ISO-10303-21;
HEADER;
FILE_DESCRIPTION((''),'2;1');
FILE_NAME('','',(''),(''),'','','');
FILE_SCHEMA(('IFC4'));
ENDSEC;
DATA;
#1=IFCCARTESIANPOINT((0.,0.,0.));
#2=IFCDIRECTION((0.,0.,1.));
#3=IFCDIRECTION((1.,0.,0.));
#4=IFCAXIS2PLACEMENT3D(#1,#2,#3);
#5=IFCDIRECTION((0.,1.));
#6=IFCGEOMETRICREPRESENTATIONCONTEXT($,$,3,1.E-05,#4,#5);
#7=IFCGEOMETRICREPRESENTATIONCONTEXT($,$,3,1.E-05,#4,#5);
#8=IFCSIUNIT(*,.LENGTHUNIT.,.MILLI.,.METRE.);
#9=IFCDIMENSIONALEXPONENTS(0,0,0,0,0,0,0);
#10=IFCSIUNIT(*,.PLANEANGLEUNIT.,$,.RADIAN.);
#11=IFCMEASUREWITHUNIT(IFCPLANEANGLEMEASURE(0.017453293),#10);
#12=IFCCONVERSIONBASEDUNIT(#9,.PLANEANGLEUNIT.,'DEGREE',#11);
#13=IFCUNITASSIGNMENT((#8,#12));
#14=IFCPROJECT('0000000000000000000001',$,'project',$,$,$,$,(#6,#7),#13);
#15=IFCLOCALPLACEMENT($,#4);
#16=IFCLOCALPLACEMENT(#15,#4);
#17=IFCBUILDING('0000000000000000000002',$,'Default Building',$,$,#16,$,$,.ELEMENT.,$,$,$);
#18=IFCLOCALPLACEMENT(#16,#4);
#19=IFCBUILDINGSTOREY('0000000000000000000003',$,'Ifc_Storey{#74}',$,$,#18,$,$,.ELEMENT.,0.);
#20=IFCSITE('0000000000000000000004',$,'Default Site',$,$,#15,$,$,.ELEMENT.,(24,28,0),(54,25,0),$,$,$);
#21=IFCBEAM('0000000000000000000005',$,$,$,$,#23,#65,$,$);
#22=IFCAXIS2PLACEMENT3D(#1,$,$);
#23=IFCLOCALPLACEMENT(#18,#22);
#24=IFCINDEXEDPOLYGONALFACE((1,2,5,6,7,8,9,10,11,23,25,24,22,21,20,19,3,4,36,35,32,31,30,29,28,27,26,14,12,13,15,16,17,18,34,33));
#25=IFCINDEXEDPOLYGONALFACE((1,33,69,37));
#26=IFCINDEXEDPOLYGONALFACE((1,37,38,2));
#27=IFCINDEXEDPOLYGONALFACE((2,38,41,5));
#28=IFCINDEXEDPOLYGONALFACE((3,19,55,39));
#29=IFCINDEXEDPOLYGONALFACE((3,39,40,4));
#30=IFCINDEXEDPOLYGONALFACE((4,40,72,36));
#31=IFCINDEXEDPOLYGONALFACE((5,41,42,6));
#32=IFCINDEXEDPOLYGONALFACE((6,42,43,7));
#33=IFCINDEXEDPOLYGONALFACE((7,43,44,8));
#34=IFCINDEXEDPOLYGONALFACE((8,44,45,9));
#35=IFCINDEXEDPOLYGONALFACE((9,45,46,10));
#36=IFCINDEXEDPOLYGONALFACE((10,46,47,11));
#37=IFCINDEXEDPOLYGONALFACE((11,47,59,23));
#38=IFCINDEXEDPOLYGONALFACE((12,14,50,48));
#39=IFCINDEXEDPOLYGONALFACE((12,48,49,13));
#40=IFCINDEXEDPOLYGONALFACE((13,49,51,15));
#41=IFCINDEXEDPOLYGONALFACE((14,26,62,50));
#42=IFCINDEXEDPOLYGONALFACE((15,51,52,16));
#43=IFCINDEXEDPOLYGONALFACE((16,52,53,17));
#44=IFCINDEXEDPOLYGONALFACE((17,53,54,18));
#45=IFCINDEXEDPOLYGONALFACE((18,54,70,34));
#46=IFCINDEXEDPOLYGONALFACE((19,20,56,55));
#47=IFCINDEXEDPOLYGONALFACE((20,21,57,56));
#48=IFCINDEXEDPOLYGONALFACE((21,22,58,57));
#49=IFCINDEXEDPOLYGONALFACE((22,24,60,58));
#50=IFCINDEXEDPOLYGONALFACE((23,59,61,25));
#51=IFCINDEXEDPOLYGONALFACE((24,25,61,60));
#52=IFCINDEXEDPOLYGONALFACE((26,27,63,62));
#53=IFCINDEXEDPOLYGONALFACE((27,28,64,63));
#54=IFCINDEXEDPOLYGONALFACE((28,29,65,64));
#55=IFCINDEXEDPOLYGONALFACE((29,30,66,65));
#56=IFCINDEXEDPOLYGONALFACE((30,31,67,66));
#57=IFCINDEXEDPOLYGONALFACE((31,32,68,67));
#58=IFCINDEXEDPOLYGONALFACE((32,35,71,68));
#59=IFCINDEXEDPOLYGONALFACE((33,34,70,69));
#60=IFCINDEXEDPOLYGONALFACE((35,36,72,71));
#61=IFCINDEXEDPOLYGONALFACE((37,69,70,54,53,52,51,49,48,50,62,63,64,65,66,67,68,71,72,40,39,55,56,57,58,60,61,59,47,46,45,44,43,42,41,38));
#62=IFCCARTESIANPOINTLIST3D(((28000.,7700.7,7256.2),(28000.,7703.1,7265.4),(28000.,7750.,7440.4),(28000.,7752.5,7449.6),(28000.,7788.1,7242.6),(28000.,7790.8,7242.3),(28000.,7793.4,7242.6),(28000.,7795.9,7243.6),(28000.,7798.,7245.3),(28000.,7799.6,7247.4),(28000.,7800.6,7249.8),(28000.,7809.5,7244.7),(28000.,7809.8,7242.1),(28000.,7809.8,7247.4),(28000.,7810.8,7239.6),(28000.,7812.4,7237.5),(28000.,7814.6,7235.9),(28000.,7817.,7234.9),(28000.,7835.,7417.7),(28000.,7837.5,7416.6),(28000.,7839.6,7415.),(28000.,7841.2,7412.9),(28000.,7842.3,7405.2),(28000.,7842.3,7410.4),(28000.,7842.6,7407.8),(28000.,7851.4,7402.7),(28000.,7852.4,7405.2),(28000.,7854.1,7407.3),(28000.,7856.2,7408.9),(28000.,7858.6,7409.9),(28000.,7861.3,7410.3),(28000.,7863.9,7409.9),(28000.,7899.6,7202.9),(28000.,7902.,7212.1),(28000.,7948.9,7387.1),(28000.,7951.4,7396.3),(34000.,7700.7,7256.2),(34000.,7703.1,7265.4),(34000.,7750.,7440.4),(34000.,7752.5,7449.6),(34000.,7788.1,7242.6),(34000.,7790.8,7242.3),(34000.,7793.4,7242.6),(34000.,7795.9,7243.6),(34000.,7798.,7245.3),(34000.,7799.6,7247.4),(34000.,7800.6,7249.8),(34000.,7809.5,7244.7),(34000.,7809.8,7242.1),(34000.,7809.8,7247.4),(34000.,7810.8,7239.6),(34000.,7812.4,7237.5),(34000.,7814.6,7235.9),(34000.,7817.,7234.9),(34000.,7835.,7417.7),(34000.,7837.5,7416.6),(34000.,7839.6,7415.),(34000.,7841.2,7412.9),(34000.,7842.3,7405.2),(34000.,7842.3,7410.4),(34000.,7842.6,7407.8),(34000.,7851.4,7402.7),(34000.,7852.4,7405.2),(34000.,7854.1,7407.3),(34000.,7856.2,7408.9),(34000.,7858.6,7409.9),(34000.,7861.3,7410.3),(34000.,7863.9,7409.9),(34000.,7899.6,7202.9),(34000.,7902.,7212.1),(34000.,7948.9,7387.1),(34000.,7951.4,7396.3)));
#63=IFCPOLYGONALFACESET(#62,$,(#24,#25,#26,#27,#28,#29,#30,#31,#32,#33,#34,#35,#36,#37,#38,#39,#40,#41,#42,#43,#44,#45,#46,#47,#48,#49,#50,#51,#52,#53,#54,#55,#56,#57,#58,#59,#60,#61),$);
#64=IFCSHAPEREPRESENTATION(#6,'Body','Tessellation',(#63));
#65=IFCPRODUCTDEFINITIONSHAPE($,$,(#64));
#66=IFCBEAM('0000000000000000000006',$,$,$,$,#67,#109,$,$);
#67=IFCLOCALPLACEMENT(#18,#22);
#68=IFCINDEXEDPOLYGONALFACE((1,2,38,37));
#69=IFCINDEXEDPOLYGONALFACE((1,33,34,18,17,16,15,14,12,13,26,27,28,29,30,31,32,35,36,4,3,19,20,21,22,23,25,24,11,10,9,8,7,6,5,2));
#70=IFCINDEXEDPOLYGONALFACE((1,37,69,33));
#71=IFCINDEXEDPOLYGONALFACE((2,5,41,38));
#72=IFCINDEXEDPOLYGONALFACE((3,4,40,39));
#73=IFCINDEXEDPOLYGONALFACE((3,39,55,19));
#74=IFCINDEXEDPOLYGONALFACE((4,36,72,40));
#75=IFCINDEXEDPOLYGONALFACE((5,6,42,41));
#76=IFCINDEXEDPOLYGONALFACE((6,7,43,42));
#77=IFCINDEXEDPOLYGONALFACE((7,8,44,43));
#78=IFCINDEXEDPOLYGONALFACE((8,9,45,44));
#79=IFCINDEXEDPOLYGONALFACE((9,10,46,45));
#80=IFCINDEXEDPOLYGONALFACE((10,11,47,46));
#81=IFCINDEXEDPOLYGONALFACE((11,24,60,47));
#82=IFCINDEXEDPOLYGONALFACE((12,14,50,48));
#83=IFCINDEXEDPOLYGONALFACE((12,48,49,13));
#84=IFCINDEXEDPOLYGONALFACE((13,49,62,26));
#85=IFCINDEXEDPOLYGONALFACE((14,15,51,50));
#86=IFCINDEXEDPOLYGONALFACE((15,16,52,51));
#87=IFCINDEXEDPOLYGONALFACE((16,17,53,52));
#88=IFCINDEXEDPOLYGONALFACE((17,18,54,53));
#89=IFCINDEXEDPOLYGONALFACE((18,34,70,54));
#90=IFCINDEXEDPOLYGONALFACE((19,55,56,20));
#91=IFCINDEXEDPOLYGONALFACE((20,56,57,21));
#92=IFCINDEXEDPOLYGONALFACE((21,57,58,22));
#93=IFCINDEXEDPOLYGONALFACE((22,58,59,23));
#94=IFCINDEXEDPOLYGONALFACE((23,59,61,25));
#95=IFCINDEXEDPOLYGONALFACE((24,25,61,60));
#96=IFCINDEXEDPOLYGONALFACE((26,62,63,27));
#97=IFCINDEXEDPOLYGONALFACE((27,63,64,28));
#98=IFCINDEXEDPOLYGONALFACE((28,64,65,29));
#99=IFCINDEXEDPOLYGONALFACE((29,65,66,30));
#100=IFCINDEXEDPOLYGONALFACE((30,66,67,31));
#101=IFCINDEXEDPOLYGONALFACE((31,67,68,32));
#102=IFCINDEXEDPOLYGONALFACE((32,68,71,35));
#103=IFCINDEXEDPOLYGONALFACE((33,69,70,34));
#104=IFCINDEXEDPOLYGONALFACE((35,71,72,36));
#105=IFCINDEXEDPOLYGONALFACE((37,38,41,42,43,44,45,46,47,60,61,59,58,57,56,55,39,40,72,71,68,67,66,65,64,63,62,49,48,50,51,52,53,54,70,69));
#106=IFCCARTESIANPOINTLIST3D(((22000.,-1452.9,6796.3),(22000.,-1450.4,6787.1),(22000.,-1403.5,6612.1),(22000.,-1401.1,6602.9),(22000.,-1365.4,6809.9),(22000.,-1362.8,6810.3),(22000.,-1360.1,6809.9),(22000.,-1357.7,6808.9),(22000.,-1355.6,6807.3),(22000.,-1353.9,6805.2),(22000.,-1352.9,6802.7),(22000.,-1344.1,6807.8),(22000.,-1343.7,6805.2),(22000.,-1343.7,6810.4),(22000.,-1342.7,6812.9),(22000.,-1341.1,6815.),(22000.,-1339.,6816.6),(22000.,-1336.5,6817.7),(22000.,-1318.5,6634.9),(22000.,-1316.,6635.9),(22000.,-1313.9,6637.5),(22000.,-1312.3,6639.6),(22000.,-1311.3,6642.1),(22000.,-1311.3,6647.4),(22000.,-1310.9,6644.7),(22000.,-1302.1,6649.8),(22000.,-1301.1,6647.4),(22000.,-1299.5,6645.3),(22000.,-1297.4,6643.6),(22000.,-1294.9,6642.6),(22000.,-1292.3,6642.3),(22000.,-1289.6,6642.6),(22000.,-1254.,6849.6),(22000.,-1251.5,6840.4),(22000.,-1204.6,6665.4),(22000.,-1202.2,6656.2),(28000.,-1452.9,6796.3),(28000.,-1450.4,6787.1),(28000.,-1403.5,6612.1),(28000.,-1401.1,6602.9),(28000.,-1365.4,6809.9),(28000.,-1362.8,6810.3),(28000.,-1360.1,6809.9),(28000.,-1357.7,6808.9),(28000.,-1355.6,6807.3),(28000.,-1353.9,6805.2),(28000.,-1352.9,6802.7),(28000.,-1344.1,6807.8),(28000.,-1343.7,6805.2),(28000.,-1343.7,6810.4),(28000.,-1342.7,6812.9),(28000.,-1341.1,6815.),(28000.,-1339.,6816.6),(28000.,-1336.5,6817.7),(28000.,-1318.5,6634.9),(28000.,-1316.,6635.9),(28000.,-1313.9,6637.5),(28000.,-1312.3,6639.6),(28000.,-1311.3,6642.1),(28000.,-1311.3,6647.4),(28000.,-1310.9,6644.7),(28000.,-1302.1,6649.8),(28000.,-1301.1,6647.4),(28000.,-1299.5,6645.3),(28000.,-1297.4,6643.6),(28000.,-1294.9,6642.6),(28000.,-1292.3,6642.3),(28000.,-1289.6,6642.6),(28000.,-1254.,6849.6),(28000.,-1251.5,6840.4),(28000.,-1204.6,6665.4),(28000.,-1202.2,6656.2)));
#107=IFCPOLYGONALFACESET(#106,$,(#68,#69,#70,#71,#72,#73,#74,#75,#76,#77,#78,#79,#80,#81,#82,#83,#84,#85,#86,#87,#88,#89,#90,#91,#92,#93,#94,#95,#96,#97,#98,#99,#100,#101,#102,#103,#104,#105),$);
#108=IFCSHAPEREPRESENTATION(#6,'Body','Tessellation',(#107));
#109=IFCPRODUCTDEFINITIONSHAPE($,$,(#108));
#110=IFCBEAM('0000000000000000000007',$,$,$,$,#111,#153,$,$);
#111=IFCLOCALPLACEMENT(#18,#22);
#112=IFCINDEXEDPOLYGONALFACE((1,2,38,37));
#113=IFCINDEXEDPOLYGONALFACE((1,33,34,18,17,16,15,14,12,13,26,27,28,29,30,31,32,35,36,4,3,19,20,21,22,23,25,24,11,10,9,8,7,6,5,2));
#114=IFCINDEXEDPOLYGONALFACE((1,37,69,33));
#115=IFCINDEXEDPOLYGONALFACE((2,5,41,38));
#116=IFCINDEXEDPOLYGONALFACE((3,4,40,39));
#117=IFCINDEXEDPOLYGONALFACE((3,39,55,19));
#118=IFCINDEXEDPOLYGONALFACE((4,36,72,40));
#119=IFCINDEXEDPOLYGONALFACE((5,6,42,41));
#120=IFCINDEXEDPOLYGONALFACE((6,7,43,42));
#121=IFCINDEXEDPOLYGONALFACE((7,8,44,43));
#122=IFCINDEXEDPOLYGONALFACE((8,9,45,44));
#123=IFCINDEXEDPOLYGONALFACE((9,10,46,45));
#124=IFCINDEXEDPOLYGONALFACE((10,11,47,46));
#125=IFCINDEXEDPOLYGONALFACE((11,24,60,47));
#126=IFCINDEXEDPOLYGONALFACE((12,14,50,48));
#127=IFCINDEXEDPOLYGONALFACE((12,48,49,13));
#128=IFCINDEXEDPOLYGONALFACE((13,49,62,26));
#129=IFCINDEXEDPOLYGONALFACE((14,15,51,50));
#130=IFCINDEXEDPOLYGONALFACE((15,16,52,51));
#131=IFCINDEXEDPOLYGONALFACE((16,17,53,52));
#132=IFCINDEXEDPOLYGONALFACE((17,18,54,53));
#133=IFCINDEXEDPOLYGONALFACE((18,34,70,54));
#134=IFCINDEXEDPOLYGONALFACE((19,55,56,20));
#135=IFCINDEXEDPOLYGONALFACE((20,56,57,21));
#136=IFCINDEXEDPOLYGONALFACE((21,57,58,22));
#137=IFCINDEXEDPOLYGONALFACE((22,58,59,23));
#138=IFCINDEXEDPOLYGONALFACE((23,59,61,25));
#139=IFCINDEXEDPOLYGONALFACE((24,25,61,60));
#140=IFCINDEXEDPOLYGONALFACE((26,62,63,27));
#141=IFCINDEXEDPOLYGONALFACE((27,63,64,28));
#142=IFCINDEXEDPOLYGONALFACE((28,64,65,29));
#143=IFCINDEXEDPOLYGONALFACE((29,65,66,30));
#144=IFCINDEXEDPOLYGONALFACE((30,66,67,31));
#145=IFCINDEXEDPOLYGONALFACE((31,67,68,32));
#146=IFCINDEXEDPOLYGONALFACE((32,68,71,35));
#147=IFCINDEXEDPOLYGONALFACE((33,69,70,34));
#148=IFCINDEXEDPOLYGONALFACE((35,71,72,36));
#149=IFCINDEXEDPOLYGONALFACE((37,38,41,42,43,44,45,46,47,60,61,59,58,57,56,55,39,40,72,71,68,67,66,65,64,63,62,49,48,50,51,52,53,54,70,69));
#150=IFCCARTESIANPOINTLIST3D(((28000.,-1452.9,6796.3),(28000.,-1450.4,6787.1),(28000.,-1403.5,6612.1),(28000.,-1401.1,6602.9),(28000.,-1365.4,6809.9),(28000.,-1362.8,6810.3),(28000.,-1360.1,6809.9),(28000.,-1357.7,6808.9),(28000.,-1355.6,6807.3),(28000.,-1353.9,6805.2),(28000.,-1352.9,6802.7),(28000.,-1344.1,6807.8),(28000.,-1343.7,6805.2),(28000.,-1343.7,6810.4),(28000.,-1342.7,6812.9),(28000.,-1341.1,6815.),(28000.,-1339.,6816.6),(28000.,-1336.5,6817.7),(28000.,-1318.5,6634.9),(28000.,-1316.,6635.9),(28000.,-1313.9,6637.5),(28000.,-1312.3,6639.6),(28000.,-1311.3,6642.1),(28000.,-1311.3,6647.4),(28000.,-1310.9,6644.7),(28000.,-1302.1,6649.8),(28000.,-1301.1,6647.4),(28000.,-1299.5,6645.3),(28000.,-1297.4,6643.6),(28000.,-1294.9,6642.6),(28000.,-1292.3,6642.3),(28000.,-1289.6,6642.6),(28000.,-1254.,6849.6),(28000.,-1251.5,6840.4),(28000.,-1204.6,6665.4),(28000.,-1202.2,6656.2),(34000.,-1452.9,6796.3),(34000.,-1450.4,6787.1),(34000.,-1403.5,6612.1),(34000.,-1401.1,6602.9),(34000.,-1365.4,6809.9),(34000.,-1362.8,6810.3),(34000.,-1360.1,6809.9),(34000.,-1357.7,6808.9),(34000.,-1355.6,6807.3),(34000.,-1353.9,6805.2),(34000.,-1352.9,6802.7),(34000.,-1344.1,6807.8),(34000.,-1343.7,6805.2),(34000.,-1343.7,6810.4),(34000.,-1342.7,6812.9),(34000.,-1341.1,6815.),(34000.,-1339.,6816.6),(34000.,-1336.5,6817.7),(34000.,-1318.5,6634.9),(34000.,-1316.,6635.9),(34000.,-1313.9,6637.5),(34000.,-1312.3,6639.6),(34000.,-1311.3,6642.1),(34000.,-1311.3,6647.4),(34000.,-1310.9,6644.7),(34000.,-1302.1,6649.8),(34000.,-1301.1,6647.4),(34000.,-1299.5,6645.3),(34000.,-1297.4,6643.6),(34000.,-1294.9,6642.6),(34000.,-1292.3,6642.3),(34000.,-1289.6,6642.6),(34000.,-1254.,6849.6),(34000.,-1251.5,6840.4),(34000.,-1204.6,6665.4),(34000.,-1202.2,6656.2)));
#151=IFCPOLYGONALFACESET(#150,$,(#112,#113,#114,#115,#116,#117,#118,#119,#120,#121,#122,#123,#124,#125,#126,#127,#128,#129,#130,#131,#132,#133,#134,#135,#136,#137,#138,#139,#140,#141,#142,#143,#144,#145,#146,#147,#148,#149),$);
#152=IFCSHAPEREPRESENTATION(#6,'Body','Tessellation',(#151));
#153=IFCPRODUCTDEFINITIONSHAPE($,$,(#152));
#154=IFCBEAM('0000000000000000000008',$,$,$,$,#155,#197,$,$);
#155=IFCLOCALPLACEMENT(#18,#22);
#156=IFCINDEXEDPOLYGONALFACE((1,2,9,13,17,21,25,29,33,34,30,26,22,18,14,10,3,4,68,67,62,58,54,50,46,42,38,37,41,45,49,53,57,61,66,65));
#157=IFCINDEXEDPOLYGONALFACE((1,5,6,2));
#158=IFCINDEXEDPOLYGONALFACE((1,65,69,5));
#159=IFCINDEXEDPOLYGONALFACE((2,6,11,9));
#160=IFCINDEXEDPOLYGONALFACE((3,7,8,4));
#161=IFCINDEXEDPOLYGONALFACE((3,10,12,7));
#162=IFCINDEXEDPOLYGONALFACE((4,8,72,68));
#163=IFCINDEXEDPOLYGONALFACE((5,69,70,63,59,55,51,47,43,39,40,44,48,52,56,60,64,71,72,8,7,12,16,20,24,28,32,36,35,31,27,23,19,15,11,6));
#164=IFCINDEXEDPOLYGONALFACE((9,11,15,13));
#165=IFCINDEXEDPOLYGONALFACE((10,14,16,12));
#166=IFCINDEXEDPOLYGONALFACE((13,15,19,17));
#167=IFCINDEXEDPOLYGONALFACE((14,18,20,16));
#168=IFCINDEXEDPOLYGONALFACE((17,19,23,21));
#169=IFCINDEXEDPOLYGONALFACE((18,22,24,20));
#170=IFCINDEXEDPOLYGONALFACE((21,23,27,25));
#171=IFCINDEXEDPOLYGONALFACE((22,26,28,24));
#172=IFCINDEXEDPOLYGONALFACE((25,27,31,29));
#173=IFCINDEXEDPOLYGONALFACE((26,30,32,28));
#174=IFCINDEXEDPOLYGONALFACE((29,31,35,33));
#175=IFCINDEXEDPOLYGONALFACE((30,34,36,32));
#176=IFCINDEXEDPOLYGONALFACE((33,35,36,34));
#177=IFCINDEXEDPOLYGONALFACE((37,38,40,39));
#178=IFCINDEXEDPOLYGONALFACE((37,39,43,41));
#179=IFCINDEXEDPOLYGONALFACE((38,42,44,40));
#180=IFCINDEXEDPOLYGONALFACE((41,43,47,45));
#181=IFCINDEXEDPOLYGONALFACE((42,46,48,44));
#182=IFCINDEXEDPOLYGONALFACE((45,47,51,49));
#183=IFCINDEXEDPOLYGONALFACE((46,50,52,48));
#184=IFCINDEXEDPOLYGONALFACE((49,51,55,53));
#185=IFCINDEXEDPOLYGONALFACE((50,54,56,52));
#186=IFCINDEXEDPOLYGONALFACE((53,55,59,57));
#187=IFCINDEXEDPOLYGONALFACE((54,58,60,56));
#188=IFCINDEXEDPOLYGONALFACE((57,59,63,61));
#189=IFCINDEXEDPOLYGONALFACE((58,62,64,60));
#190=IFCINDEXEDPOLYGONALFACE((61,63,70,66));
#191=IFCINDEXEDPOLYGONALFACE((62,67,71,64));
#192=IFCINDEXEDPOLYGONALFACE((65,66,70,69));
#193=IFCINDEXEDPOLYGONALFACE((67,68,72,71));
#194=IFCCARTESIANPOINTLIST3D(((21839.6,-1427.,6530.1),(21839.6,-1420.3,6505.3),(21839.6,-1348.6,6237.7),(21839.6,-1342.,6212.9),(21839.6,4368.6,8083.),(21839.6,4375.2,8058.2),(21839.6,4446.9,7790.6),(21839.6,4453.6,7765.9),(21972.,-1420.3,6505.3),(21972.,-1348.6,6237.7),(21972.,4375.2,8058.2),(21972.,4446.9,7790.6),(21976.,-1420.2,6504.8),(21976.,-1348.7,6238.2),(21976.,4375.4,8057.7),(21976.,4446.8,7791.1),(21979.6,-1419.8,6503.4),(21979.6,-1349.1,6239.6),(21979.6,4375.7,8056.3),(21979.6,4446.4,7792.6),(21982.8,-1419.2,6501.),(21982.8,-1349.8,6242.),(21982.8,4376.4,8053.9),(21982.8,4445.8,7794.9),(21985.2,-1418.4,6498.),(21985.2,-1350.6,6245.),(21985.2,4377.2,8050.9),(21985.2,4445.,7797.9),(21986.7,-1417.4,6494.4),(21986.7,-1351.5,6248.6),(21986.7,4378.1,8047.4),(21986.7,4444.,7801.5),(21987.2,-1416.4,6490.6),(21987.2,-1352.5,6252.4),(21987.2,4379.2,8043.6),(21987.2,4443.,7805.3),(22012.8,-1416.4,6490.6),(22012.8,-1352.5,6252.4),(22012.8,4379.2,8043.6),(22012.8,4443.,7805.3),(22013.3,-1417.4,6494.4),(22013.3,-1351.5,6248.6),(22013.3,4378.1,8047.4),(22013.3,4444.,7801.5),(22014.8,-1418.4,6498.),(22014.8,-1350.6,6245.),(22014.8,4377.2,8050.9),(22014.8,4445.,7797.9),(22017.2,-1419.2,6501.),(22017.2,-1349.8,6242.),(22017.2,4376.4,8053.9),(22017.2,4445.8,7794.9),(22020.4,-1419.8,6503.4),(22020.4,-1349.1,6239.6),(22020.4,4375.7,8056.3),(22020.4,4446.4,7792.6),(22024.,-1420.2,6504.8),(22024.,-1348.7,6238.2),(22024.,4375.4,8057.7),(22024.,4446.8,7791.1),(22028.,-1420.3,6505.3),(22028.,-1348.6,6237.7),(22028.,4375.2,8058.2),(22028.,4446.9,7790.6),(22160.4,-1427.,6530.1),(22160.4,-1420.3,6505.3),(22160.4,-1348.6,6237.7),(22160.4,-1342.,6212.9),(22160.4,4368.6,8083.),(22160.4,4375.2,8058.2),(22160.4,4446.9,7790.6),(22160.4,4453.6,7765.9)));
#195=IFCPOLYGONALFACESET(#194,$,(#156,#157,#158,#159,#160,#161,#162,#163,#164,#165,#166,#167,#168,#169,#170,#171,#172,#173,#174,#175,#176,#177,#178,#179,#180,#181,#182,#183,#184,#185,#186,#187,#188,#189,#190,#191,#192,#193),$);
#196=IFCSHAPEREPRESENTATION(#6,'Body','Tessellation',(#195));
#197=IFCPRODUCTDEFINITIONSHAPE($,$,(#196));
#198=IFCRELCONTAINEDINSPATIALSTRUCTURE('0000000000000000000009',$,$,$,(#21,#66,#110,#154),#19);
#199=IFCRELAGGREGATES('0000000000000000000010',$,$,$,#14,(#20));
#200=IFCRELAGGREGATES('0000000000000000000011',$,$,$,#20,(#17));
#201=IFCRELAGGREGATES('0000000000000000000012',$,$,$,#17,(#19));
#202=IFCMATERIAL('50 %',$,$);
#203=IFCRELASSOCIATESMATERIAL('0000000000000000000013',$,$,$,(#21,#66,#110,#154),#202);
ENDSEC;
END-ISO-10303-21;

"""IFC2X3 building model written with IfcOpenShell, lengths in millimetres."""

from ifc_helpers import new_model, entity, si_unit, converted_unit, direction, frame, origin_with_axes, origin_2d_with_axis, place, context, project, spatial, i_section, extrude, material, element, save


model = new_model("IFC2X3")

# Units and contexts
context_of_model_1 = context(None, 3, precision=1e-05, world=origin_with_axes(), true_north=direction((0.0, 1.0)))
context_of_model_2 = context(None, 3, precision=1e-05, world=origin_with_axes(), true_north=direction((0.0, 1.0)))
ifc_project = project(units=[si_unit("LENGTHUNIT", "METRE", prefix="MILLI"), converted_unit("PLANEANGLEUNIT", "DEGREE", entity("IfcPlaneAngleMeasure", 0.017453293), si_unit("PLANEANGLEUNIT", "RADIAN"), dimensions=[0, 0, 0, 0, 0, 0, 0])], contexts=[context_of_model_1, context_of_model_2])

# Site, building, storey
site_placement = place(None, origin_with_axes())
site = spatial("IfcSite", under=ifc_project, at=site_placement, Name="Default Site", CompositionType="ELEMENT", RefLatitude=(24, 28, 0), RefLongitude=(54, 25, 0))
building_placement = place(site_placement, origin_with_axes())
building = spatial("IfcBuilding", under=site, at=building_placement, Name="Default Building", CompositionType="ELEMENT")
storey_placement = place(building_placement, origin_with_axes())
storey = spatial("IfcBuildingStorey", under=building, at=storey_placement, Name="Ifc_Storey{#74}", CompositionType="ELEMENT", Elevation=0.0)

# Shared definitions
ifc_material_1 = material(Name="50 %")

# Beams
for number, where, z_axis, x_axis in (
    (1, (28000.0, 7826.0, 7326.3), (0.0, 0.258819, 0.965926), (1.0, 0.0, 0.0)),
):
    element("IfcBeam", number, at=place(storey_placement, frame(where, z_axis=z_axis, x_axis=x_axis)), inside=storey, material=ifc_material_1, context=context_of_model_1, shape_type="SweptSolid", body=[
        extrude(i_section(OverallWidth=205.9, OverallDepth=200.2, WebThickness=9.5, FlangeThickness=9.5, FilletRadius=10.2, at=origin_2d_with_axis()), frame((0.0, 0.0, 0.0), z_axis=(1.0, 0.0, 0.0), x_axis=(0.0, 1.0, 0.0)), (0.0, 0.0, 1.0), 6000.0),
    ])
for number, where, z_axis, x_axis in (
    (2, (22000.0, -1327.5, 6726.3), (0.0, -0.258819, 0.965926), (-1.0, 0.0, 0.0)),
    (3, (28000.0, -1327.5, 6726.3), (0.0, -0.258819, 0.965926), (-1.0, 0.0, 0.0)),
):
    element("IfcBeam", number, at=place(storey_placement, frame(where, z_axis=z_axis, x_axis=x_axis)), inside=storey, material=ifc_material_1, context=context_of_model_1, shape_type="SweptSolid", body=[
        extrude(i_section(OverallWidth=205.9, OverallDepth=200.2, WebThickness=9.5, FlangeThickness=9.5, FilletRadius=10.2, at=origin_2d_with_axis()), frame((0.0, 0.0, 0.0), z_axis=(-1.0, 0.0, 0.0), x_axis=(0.0, 1.0, 0.0)), (0.0, 0.0, 1.0), 6000.0),
    ])
beam_1_placement = place(storey_placement, frame((22000.0, -1384.5, 6371.5), z_axis=(0.0, 0.0, 1.0), x_axis=(0.0, -1.0, 0.0)))
element("IfcBeam", 4, at=beam_1_placement, inside=storey, material=ifc_material_1, context=context_of_model_1, shape_type="SweptSolid", body=[
    extrude(i_section(OverallWidth=320.9, OverallDepth=328.3, WebThickness=25.5, FlangeThickness=25.6, FilletRadius=15.2, at=origin_2d_with_axis()), frame((0.0, 0.0, 0.0), z_axis=(-0.965926, 0.0, 0.258819), x_axis=(0.0, 1.0, 0.0)), (0.0, 0.0, 1.0), 6000.0),
])

save(model, "model.ifc")
